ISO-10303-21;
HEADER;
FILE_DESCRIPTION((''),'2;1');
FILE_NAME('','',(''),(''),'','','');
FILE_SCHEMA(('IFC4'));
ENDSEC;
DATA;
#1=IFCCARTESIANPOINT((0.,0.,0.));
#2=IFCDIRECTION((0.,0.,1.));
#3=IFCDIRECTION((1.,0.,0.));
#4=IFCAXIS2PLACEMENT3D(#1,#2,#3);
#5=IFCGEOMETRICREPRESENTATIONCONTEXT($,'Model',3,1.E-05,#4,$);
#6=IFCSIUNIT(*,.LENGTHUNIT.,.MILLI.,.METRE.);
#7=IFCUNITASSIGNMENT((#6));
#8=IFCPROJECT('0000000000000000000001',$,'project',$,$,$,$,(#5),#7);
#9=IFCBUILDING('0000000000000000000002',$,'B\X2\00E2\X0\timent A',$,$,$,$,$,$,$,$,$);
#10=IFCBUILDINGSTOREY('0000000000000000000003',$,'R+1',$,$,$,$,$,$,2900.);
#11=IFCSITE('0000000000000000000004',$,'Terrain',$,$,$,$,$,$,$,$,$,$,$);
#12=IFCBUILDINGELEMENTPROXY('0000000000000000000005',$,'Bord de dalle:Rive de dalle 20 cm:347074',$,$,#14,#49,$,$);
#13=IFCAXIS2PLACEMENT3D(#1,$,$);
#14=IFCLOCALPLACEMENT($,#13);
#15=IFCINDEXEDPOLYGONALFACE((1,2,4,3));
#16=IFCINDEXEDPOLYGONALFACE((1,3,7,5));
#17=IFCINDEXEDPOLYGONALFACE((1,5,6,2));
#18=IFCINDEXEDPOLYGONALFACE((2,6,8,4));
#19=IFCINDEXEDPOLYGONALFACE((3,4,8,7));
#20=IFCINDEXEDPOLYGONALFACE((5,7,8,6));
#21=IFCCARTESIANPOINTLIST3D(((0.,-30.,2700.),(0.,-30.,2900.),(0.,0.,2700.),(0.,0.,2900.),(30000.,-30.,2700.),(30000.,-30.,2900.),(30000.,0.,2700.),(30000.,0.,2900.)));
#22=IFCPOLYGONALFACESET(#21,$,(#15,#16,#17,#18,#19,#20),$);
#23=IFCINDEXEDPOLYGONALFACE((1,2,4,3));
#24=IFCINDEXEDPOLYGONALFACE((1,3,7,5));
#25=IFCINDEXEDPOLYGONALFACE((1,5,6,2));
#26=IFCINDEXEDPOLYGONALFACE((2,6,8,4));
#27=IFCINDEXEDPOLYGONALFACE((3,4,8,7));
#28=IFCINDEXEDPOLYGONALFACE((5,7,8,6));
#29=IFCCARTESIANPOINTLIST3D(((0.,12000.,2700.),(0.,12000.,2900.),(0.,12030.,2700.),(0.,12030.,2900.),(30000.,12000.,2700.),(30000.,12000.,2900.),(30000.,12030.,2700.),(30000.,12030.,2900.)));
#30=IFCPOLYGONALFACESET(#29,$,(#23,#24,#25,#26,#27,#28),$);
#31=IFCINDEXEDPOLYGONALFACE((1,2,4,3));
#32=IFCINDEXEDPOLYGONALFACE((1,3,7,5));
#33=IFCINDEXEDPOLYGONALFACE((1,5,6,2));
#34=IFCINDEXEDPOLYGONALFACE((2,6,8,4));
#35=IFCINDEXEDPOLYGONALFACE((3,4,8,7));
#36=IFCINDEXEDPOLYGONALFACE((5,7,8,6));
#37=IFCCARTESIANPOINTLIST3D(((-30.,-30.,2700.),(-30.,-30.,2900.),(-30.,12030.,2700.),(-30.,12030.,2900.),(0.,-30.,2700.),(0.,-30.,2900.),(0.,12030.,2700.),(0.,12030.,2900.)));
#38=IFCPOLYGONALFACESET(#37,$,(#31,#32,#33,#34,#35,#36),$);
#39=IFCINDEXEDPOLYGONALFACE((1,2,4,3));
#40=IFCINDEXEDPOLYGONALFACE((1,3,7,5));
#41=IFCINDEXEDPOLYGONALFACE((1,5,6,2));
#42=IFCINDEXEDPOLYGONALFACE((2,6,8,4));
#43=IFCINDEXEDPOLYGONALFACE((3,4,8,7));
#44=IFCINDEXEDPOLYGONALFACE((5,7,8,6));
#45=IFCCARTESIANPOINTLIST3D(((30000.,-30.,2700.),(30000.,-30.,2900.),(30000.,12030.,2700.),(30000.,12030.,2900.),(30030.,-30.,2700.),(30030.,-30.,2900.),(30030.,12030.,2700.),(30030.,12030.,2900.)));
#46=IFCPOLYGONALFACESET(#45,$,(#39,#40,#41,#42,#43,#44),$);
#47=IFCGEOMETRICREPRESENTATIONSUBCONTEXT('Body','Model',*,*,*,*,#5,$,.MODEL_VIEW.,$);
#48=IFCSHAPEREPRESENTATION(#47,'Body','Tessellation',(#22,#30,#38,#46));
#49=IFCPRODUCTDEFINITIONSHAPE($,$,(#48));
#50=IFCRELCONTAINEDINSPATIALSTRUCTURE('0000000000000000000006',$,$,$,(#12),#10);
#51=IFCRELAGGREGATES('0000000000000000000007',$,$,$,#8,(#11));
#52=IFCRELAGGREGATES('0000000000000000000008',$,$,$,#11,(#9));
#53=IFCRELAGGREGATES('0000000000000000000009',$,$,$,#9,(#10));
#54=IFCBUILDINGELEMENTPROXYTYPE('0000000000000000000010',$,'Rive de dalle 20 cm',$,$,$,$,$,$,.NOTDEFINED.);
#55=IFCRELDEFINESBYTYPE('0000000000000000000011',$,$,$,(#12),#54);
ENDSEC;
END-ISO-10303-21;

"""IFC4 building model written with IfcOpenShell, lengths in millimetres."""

from ifc_helpers import new_model, si_unit, frame, frame_2d, origin_with_axes, place, context, subcontext, project, spatial, rectangle, extrude, type_object, element, save


model = new_model("IFC4")

# Units and contexts
model_context = context("Model", 3, precision=1e-05, world=origin_with_axes())
body_context = subcontext(model_context, "Body", "Model", "MODEL_VIEW")
ifc_project = project(units=[si_unit("LENGTHUNIT", "METRE", prefix="MILLI")], contexts=[model_context])

# Site, building, storey
site = spatial("IfcSite", under=ifc_project, Name="Terrain")
building = spatial("IfcBuilding", under=site, Name="Bâtiment A")
storey = spatial("IfcBuildingStorey", under=building, Name="R+1", Elevation=2900.0)

# Building element proxy
building_element_proxy_type = type_object("IfcBuildingElementProxyType", Name="Rive de dalle 20 cm", PredefinedType="NOTDEFINED")
proxy_placement = place(None, origin_with_axes())
element("IfcBuildingElementProxy", 1, at=proxy_placement, inside=storey, type_object=building_element_proxy_type, Name="Bord de dalle:Rive de dalle 20 cm:347074", context=body_context, shape_type="SweptSolid", body=[
    extrude(rectangle(XDim=30000.0, YDim=30.0, at=frame_2d((15000.0, -15.0))), frame((0.0, 0.0, 2700.0), z_axis=(0.0, 0.0, 1.0), x_axis=(1.0, 0.0, 0.0)), (0.0, 0.0, 1.0), 200.0),
    extrude(rectangle(XDim=30000.0, YDim=30.0, at=frame_2d((15000.0, 12015.0))), frame((0.0, 0.0, 2700.0), z_axis=(0.0, 0.0, 1.0), x_axis=(1.0, 0.0, 0.0)), (0.0, 0.0, 1.0), 200.0),
    extrude(rectangle(XDim=30.0, YDim=12060.0, at=frame_2d((-15.0, 6000.0))), frame((0.0, 0.0, 2700.0), z_axis=(0.0, 0.0, 1.0), x_axis=(1.0, 0.0, 0.0)), (0.0, 0.0, 1.0), 200.0),
    extrude(rectangle(XDim=30.0, YDim=12060.0, at=frame_2d((30015.0, 6000.0))), frame((0.0, 0.0, 2700.0), z_axis=(0.0, 0.0, 1.0), x_axis=(1.0, 0.0, 0.0)), (0.0, 0.0, 1.0), 200.0),
])

save(model, "model.ifc")
